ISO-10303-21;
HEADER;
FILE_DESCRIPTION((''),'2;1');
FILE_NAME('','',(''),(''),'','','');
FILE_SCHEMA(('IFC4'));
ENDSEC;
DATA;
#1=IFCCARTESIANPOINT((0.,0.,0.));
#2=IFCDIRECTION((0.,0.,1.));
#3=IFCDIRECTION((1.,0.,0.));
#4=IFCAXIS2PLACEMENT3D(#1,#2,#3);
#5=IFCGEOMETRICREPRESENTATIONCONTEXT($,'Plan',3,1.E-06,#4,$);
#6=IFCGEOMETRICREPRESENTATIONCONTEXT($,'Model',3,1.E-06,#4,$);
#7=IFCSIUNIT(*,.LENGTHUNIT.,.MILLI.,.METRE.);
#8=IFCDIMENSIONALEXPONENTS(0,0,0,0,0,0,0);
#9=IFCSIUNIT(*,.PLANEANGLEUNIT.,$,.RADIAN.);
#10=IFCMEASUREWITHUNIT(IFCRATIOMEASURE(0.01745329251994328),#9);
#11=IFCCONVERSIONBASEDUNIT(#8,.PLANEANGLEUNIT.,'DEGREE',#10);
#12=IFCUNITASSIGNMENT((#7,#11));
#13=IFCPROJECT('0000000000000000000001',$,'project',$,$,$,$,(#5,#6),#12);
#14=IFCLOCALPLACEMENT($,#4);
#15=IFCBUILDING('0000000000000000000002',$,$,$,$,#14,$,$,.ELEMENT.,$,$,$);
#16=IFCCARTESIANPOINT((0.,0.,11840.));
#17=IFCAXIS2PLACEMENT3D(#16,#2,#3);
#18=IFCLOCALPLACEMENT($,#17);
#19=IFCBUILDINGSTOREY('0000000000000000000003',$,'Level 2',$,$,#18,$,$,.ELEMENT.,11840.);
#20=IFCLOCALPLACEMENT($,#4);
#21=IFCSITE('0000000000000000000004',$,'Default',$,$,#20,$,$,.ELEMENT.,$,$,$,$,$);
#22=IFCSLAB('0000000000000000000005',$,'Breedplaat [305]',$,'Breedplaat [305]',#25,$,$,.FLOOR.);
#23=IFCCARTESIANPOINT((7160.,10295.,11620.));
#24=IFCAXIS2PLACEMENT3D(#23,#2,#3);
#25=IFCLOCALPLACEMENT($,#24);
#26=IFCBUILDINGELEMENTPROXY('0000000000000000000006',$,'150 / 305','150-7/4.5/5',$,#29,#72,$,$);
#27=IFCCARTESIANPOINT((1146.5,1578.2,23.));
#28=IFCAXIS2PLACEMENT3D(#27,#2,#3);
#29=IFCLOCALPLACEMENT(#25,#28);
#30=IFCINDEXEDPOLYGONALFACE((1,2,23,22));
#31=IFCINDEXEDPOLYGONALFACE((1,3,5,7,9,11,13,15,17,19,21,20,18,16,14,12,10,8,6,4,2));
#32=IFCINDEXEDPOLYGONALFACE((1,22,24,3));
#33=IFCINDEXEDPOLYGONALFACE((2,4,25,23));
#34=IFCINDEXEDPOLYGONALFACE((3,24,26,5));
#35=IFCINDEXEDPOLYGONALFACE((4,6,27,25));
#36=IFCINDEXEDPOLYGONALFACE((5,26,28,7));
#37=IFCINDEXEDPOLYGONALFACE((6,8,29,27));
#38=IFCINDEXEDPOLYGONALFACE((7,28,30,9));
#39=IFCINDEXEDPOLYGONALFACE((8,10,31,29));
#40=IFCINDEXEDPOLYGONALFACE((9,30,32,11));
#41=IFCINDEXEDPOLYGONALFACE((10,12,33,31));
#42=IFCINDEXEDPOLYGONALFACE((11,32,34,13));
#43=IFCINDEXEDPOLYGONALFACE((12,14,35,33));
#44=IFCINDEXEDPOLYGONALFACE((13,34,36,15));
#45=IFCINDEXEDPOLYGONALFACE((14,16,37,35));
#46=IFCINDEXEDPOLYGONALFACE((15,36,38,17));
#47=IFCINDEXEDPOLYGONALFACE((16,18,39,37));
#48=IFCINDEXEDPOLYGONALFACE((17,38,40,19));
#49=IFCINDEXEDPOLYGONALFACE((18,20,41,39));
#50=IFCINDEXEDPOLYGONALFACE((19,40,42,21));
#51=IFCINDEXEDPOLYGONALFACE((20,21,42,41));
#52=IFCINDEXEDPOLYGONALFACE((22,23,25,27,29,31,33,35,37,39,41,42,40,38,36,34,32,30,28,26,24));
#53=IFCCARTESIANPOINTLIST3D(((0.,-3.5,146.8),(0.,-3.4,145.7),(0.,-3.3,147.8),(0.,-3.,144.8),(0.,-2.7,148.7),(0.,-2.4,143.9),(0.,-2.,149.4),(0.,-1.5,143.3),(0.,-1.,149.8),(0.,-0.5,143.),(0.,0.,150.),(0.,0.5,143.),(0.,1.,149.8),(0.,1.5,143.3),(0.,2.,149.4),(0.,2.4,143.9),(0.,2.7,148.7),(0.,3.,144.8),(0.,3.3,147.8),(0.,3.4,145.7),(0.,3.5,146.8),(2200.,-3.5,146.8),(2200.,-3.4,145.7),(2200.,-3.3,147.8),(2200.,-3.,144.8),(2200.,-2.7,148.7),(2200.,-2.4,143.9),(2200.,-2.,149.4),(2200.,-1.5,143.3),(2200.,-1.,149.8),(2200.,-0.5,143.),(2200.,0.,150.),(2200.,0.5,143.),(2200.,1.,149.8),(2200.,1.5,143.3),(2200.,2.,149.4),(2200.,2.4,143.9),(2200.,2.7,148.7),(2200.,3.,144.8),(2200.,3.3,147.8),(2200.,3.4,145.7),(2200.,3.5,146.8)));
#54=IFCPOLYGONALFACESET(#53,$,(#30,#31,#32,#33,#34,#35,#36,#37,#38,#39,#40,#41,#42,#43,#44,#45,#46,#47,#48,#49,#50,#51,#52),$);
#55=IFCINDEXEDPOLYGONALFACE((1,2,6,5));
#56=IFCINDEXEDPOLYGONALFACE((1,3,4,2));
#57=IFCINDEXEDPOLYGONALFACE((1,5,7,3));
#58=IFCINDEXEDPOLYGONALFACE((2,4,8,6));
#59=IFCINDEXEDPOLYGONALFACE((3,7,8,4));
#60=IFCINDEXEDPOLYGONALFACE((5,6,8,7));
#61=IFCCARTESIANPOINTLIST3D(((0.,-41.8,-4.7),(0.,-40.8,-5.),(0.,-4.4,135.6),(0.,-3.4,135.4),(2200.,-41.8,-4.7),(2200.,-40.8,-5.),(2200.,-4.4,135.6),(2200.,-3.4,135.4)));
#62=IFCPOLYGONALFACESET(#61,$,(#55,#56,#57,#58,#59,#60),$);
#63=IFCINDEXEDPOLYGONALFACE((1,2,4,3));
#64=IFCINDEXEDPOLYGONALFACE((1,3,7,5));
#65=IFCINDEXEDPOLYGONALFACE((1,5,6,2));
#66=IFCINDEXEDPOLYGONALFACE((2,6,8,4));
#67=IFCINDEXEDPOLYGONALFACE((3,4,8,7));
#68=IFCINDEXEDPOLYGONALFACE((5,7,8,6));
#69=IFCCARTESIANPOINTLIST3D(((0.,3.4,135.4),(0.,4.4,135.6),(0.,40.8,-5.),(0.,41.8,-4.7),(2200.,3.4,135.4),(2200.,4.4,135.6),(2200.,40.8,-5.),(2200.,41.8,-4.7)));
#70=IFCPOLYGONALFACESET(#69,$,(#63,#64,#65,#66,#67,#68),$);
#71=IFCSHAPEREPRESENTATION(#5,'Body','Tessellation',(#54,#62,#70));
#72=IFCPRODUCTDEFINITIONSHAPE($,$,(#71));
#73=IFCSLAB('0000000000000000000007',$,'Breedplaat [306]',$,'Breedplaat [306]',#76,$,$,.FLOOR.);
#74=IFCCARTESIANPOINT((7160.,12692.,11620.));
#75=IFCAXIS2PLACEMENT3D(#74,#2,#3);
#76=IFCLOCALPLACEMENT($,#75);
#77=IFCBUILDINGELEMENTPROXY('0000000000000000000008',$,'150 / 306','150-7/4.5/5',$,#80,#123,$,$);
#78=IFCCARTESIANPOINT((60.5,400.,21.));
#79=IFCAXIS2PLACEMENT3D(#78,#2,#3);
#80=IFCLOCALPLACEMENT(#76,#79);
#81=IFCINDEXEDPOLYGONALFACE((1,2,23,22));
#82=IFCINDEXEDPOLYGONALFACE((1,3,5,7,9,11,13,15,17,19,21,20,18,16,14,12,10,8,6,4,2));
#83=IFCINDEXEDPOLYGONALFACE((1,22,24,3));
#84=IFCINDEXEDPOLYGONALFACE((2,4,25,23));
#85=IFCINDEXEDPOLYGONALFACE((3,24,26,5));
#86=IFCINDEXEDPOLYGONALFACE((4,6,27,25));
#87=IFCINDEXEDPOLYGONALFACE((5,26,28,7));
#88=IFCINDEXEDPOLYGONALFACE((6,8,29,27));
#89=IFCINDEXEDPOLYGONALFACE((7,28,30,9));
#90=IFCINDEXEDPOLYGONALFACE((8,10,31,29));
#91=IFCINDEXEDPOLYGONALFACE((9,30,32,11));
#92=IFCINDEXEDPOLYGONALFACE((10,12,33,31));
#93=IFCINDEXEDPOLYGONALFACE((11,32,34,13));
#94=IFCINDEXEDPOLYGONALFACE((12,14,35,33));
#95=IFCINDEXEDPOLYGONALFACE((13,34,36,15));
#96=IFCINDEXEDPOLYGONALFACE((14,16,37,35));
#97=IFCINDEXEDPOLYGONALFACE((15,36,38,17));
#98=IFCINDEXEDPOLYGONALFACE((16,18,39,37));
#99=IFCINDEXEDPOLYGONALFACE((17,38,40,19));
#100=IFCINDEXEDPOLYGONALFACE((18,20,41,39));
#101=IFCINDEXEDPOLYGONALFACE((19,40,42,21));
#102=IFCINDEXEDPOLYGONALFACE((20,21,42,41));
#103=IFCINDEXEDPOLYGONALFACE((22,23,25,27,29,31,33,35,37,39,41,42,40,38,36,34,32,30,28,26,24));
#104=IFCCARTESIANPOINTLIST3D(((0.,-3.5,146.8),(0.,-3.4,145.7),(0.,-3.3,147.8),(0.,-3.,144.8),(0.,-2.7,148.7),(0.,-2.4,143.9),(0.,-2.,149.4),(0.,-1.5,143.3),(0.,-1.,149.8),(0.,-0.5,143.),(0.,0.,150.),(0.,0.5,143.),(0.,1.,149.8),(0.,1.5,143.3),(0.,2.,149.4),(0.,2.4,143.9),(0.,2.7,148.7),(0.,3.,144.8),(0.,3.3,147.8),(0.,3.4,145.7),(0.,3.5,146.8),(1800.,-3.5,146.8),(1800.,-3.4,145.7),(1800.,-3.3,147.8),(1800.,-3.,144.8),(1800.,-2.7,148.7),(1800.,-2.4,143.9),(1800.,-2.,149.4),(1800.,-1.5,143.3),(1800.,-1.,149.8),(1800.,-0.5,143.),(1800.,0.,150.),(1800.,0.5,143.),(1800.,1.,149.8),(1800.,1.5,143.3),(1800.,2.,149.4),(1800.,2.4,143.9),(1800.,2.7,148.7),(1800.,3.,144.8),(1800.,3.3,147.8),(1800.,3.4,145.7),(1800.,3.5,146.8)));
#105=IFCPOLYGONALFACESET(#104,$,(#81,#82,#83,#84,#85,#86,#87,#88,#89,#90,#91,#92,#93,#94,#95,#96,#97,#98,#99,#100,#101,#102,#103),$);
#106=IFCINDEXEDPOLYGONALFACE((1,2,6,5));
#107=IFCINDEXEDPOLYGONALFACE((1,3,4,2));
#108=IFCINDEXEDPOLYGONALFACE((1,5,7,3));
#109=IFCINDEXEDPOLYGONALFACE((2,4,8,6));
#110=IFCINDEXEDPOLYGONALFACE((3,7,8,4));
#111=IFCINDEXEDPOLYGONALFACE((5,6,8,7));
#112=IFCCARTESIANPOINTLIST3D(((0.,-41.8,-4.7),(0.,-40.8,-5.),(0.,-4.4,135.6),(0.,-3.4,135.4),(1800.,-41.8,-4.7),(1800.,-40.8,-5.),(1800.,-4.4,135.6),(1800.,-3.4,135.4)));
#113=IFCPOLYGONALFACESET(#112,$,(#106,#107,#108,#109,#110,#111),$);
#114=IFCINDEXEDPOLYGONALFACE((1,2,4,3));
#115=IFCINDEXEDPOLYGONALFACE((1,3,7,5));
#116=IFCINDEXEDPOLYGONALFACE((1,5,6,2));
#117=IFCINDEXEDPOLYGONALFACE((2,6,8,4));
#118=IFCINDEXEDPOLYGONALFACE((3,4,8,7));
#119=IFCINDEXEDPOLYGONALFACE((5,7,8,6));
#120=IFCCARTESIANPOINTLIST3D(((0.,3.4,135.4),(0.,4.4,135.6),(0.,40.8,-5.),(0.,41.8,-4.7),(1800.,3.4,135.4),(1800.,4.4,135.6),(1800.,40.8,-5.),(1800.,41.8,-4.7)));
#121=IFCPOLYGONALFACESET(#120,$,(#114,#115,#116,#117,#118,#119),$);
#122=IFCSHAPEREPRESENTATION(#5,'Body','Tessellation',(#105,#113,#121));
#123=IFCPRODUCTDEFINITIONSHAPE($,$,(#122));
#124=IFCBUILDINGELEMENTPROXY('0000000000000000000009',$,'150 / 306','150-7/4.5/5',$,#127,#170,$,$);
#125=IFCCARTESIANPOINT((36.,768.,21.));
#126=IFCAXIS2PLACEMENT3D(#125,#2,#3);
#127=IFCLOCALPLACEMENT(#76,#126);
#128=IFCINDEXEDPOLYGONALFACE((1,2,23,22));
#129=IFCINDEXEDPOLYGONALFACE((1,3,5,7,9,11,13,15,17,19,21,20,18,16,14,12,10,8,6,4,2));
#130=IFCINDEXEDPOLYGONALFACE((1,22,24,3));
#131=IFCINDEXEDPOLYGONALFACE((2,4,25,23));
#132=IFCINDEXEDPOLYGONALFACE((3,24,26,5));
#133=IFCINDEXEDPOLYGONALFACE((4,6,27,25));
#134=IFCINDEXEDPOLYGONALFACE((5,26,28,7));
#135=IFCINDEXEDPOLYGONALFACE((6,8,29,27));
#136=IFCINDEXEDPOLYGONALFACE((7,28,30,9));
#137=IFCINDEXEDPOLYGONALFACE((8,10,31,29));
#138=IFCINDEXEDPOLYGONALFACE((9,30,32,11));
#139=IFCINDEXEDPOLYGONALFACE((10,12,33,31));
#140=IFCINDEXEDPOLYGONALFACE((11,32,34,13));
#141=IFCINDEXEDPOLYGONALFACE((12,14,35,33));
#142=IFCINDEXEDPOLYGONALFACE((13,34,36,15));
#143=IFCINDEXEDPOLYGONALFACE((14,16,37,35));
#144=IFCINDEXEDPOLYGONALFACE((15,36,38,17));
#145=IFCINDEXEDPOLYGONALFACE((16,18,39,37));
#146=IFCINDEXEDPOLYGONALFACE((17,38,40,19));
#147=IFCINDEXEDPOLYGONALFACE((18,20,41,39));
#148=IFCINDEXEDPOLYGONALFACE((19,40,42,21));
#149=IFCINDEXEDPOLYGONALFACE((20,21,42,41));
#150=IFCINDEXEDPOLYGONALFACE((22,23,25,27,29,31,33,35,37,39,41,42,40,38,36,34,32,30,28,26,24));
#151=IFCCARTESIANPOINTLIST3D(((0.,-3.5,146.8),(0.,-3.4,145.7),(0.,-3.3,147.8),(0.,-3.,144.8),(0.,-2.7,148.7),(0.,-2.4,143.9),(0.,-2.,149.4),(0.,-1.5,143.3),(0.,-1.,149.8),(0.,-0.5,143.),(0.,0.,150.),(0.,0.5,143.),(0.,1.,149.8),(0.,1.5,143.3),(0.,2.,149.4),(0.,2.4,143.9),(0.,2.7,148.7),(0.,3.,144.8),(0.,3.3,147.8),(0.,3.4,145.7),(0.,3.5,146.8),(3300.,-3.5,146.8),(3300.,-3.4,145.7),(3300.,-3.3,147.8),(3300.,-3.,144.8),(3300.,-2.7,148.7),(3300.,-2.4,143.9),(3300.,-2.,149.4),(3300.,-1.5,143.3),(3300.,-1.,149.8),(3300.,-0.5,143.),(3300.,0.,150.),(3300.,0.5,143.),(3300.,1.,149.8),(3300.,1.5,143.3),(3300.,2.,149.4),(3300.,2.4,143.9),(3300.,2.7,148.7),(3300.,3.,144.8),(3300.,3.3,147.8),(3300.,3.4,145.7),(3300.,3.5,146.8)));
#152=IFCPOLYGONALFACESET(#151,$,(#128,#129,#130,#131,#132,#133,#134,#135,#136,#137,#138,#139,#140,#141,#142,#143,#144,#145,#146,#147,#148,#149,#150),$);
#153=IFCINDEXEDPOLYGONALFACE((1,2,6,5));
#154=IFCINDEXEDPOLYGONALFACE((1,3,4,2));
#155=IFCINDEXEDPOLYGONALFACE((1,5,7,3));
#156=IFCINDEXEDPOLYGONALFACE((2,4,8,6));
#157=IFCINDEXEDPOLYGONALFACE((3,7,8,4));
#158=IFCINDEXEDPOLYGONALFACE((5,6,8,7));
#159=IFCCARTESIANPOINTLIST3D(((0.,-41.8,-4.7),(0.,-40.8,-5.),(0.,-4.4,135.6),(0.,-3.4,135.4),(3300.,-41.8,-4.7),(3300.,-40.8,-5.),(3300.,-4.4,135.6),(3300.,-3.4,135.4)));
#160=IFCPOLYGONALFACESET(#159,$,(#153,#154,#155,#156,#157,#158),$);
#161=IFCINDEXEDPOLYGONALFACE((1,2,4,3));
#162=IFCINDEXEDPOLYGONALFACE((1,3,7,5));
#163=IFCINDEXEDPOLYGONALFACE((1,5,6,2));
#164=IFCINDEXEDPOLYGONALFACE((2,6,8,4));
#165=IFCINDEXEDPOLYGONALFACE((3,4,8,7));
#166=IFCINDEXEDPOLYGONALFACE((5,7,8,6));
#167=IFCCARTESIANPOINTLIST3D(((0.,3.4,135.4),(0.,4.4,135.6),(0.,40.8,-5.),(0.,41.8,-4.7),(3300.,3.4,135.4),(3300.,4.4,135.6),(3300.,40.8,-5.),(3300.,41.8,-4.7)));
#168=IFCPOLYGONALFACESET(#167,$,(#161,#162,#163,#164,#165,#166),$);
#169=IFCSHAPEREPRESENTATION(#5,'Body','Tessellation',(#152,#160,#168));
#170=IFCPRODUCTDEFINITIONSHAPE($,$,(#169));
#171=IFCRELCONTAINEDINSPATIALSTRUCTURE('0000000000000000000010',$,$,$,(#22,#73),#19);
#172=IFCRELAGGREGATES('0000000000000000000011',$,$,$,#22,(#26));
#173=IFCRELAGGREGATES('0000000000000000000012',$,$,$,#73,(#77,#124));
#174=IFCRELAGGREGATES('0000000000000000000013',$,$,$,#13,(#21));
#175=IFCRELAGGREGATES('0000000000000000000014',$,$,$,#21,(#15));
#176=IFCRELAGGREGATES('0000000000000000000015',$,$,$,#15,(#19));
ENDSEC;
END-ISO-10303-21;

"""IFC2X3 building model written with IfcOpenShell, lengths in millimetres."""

from ifc_helpers import new_model, entity, si_unit, converted_unit, frame, origin_with_axes, origin_2d_with_axis, place, context, project, spatial, rectangle, circle, extrude, element, aggregate, save


model = new_model("IFC2X3")

# Units and contexts
plan_context = context("Plan", 3, precision=1e-06, world=origin_with_axes())
model_context = context("Model", 3, precision=1e-06, world=origin_with_axes())
ifc_project = project(units=[si_unit("LENGTHUNIT", "METRE", prefix="MILLI"), converted_unit("PLANEANGLEUNIT", "DEGREE", entity("IfcRatioMeasure", 0.01745329251994328), si_unit("PLANEANGLEUNIT", "RADIAN"), dimensions=[0, 0, 0, 0, 0, 0, 0])], contexts=[plan_context, model_context])

# Site, building, storey
site_placement = place(None, origin_with_axes())
site = spatial("IfcSite", under=ifc_project, at=site_placement, Name="Default", CompositionType="ELEMENT")
building_placement = place(None, origin_with_axes())
building = spatial("IfcBuilding", under=site, at=building_placement, CompositionType="ELEMENT")
storey_placement = place(None, frame((0.0, 0.0, 11840.0), z_axis=(0.0, 0.0, 1.0), x_axis=(1.0, 0.0, 0.0)))
storey = spatial("IfcBuildingStorey", under=building, at=storey_placement, Name="Level 2", CompositionType="ELEMENT", Elevation=11840.0)

# Slabs, building element proxies
slab_1_placement = place(None, frame((7160.0, 10295.0, 11620.0), z_axis=(0.0, 0.0, 1.0), x_axis=(1.0, 0.0, 0.0)))
slab_1 = element("IfcSlab", 1, at=slab_1_placement, inside=storey, Name="Breedplaat [305]", ObjectType="Breedplaat [305]", PredefinedType="FLOOR")
proxy_1_placement = place(slab_1_placement, frame((1146.5, 1578.2, 23.0), z_axis=(0.0, 0.0, 1.0), x_axis=(1.0, 0.0, 0.0)))
proxy_1 = element("IfcBuildingElementProxy", 2, at=proxy_1_placement, Name="150 / 305", Description="150-7/4.5/5", context=plan_context, shape_type="SweptSolid", body=[
    extrude(circle(Radius=3.5, at=origin_2d_with_axis()), frame((0.0, 0.0, 146.5), z_axis=(1.0, 0.0, 0.0), x_axis=(0.0, 0.0, 1.0)), (0.0, 0.0, 1.0), 2200.0),
    extrude(rectangle(XDim=145.2, YDim=1.0, at=origin_2d_with_axis()), frame((0.0, -22.6, 65.3), z_axis=(1.0, 0.0, 0.0), x_axis=(0.0, 0.257663, 0.966235)), (0.0, 0.0, 1.0), 2200.0),
    extrude(rectangle(XDim=145.2, YDim=1.0, at=origin_2d_with_axis()), frame((0.0, 22.6, 65.3), z_axis=(1.0, 0.0, 0.0), x_axis=(0.0, -0.257663, 0.966235)), (0.0, 0.0, 1.0), 2200.0),
])
aggregate(slab_1, [proxy_1])
slab_2_placement = place(None, frame((7160.0, 12692.0, 11620.0), z_axis=(0.0, 0.0, 1.0), x_axis=(1.0, 0.0, 0.0)))
slab_2 = element("IfcSlab", 3, at=slab_2_placement, inside=storey, Name="Breedplaat [306]", ObjectType="Breedplaat [306]", PredefinedType="FLOOR")
proxy_2_placement = place(slab_2_placement, frame((60.5, 400.0, 21.0), z_axis=(0.0, 0.0, 1.0), x_axis=(1.0, 0.0, 0.0)))
proxy_2 = element("IfcBuildingElementProxy", 4, at=proxy_2_placement, Name="150 / 306", Description="150-7/4.5/5", context=plan_context, shape_type="SweptSolid", body=[
    extrude(circle(Radius=3.5, at=origin_2d_with_axis()), frame((0.0, 0.0, 146.5), z_axis=(1.0, 0.0, 0.0), x_axis=(0.0, 0.0, 1.0)), (0.0, 0.0, 1.0), 1800.0),
    extrude(rectangle(XDim=145.2, YDim=1.0, at=origin_2d_with_axis()), frame((0.0, -22.6, 65.3), z_axis=(1.0, 0.0, 0.0), x_axis=(0.0, 0.257663, 0.966235)), (0.0, 0.0, 1.0), 1800.0),
    extrude(rectangle(XDim=145.2, YDim=1.0, at=origin_2d_with_axis()), frame((0.0, 22.6, 65.3), z_axis=(1.0, 0.0, 0.0), x_axis=(0.0, -0.257663, 0.966235)), (0.0, 0.0, 1.0), 1800.0),
])
proxy_3_placement = place(slab_2_placement, frame((36.0, 768.0, 21.0), z_axis=(0.0, 0.0, 1.0), x_axis=(1.0, 0.0, 0.0)))
proxy_3 = element("IfcBuildingElementProxy", 5, at=proxy_3_placement, Name="150 / 306", Description="150-7/4.5/5", context=plan_context, shape_type="SweptSolid", body=[
    extrude(circle(Radius=3.5, at=origin_2d_with_axis()), frame((0.0, 0.0, 146.5), z_axis=(1.0, 0.0, 0.0), x_axis=(0.0, 0.0, 1.0)), (0.0, 0.0, 1.0), 3300.0),
    extrude(rectangle(XDim=145.2, YDim=1.0, at=origin_2d_with_axis()), frame((0.0, -22.6, 65.3), z_axis=(1.0, 0.0, 0.0), x_axis=(0.0, 0.257663, 0.966235)), (0.0, 0.0, 1.0), 3300.0),
    extrude(rectangle(XDim=145.2, YDim=1.0, at=origin_2d_with_axis()), frame((0.0, 22.6, 65.3), z_axis=(1.0, 0.0, 0.0), x_axis=(0.0, -0.257663, 0.966235)), (0.0, 0.0, 1.0), 3300.0),
])
aggregate(slab_2, [proxy_2, proxy_3])

save(model, "model.ifc")
